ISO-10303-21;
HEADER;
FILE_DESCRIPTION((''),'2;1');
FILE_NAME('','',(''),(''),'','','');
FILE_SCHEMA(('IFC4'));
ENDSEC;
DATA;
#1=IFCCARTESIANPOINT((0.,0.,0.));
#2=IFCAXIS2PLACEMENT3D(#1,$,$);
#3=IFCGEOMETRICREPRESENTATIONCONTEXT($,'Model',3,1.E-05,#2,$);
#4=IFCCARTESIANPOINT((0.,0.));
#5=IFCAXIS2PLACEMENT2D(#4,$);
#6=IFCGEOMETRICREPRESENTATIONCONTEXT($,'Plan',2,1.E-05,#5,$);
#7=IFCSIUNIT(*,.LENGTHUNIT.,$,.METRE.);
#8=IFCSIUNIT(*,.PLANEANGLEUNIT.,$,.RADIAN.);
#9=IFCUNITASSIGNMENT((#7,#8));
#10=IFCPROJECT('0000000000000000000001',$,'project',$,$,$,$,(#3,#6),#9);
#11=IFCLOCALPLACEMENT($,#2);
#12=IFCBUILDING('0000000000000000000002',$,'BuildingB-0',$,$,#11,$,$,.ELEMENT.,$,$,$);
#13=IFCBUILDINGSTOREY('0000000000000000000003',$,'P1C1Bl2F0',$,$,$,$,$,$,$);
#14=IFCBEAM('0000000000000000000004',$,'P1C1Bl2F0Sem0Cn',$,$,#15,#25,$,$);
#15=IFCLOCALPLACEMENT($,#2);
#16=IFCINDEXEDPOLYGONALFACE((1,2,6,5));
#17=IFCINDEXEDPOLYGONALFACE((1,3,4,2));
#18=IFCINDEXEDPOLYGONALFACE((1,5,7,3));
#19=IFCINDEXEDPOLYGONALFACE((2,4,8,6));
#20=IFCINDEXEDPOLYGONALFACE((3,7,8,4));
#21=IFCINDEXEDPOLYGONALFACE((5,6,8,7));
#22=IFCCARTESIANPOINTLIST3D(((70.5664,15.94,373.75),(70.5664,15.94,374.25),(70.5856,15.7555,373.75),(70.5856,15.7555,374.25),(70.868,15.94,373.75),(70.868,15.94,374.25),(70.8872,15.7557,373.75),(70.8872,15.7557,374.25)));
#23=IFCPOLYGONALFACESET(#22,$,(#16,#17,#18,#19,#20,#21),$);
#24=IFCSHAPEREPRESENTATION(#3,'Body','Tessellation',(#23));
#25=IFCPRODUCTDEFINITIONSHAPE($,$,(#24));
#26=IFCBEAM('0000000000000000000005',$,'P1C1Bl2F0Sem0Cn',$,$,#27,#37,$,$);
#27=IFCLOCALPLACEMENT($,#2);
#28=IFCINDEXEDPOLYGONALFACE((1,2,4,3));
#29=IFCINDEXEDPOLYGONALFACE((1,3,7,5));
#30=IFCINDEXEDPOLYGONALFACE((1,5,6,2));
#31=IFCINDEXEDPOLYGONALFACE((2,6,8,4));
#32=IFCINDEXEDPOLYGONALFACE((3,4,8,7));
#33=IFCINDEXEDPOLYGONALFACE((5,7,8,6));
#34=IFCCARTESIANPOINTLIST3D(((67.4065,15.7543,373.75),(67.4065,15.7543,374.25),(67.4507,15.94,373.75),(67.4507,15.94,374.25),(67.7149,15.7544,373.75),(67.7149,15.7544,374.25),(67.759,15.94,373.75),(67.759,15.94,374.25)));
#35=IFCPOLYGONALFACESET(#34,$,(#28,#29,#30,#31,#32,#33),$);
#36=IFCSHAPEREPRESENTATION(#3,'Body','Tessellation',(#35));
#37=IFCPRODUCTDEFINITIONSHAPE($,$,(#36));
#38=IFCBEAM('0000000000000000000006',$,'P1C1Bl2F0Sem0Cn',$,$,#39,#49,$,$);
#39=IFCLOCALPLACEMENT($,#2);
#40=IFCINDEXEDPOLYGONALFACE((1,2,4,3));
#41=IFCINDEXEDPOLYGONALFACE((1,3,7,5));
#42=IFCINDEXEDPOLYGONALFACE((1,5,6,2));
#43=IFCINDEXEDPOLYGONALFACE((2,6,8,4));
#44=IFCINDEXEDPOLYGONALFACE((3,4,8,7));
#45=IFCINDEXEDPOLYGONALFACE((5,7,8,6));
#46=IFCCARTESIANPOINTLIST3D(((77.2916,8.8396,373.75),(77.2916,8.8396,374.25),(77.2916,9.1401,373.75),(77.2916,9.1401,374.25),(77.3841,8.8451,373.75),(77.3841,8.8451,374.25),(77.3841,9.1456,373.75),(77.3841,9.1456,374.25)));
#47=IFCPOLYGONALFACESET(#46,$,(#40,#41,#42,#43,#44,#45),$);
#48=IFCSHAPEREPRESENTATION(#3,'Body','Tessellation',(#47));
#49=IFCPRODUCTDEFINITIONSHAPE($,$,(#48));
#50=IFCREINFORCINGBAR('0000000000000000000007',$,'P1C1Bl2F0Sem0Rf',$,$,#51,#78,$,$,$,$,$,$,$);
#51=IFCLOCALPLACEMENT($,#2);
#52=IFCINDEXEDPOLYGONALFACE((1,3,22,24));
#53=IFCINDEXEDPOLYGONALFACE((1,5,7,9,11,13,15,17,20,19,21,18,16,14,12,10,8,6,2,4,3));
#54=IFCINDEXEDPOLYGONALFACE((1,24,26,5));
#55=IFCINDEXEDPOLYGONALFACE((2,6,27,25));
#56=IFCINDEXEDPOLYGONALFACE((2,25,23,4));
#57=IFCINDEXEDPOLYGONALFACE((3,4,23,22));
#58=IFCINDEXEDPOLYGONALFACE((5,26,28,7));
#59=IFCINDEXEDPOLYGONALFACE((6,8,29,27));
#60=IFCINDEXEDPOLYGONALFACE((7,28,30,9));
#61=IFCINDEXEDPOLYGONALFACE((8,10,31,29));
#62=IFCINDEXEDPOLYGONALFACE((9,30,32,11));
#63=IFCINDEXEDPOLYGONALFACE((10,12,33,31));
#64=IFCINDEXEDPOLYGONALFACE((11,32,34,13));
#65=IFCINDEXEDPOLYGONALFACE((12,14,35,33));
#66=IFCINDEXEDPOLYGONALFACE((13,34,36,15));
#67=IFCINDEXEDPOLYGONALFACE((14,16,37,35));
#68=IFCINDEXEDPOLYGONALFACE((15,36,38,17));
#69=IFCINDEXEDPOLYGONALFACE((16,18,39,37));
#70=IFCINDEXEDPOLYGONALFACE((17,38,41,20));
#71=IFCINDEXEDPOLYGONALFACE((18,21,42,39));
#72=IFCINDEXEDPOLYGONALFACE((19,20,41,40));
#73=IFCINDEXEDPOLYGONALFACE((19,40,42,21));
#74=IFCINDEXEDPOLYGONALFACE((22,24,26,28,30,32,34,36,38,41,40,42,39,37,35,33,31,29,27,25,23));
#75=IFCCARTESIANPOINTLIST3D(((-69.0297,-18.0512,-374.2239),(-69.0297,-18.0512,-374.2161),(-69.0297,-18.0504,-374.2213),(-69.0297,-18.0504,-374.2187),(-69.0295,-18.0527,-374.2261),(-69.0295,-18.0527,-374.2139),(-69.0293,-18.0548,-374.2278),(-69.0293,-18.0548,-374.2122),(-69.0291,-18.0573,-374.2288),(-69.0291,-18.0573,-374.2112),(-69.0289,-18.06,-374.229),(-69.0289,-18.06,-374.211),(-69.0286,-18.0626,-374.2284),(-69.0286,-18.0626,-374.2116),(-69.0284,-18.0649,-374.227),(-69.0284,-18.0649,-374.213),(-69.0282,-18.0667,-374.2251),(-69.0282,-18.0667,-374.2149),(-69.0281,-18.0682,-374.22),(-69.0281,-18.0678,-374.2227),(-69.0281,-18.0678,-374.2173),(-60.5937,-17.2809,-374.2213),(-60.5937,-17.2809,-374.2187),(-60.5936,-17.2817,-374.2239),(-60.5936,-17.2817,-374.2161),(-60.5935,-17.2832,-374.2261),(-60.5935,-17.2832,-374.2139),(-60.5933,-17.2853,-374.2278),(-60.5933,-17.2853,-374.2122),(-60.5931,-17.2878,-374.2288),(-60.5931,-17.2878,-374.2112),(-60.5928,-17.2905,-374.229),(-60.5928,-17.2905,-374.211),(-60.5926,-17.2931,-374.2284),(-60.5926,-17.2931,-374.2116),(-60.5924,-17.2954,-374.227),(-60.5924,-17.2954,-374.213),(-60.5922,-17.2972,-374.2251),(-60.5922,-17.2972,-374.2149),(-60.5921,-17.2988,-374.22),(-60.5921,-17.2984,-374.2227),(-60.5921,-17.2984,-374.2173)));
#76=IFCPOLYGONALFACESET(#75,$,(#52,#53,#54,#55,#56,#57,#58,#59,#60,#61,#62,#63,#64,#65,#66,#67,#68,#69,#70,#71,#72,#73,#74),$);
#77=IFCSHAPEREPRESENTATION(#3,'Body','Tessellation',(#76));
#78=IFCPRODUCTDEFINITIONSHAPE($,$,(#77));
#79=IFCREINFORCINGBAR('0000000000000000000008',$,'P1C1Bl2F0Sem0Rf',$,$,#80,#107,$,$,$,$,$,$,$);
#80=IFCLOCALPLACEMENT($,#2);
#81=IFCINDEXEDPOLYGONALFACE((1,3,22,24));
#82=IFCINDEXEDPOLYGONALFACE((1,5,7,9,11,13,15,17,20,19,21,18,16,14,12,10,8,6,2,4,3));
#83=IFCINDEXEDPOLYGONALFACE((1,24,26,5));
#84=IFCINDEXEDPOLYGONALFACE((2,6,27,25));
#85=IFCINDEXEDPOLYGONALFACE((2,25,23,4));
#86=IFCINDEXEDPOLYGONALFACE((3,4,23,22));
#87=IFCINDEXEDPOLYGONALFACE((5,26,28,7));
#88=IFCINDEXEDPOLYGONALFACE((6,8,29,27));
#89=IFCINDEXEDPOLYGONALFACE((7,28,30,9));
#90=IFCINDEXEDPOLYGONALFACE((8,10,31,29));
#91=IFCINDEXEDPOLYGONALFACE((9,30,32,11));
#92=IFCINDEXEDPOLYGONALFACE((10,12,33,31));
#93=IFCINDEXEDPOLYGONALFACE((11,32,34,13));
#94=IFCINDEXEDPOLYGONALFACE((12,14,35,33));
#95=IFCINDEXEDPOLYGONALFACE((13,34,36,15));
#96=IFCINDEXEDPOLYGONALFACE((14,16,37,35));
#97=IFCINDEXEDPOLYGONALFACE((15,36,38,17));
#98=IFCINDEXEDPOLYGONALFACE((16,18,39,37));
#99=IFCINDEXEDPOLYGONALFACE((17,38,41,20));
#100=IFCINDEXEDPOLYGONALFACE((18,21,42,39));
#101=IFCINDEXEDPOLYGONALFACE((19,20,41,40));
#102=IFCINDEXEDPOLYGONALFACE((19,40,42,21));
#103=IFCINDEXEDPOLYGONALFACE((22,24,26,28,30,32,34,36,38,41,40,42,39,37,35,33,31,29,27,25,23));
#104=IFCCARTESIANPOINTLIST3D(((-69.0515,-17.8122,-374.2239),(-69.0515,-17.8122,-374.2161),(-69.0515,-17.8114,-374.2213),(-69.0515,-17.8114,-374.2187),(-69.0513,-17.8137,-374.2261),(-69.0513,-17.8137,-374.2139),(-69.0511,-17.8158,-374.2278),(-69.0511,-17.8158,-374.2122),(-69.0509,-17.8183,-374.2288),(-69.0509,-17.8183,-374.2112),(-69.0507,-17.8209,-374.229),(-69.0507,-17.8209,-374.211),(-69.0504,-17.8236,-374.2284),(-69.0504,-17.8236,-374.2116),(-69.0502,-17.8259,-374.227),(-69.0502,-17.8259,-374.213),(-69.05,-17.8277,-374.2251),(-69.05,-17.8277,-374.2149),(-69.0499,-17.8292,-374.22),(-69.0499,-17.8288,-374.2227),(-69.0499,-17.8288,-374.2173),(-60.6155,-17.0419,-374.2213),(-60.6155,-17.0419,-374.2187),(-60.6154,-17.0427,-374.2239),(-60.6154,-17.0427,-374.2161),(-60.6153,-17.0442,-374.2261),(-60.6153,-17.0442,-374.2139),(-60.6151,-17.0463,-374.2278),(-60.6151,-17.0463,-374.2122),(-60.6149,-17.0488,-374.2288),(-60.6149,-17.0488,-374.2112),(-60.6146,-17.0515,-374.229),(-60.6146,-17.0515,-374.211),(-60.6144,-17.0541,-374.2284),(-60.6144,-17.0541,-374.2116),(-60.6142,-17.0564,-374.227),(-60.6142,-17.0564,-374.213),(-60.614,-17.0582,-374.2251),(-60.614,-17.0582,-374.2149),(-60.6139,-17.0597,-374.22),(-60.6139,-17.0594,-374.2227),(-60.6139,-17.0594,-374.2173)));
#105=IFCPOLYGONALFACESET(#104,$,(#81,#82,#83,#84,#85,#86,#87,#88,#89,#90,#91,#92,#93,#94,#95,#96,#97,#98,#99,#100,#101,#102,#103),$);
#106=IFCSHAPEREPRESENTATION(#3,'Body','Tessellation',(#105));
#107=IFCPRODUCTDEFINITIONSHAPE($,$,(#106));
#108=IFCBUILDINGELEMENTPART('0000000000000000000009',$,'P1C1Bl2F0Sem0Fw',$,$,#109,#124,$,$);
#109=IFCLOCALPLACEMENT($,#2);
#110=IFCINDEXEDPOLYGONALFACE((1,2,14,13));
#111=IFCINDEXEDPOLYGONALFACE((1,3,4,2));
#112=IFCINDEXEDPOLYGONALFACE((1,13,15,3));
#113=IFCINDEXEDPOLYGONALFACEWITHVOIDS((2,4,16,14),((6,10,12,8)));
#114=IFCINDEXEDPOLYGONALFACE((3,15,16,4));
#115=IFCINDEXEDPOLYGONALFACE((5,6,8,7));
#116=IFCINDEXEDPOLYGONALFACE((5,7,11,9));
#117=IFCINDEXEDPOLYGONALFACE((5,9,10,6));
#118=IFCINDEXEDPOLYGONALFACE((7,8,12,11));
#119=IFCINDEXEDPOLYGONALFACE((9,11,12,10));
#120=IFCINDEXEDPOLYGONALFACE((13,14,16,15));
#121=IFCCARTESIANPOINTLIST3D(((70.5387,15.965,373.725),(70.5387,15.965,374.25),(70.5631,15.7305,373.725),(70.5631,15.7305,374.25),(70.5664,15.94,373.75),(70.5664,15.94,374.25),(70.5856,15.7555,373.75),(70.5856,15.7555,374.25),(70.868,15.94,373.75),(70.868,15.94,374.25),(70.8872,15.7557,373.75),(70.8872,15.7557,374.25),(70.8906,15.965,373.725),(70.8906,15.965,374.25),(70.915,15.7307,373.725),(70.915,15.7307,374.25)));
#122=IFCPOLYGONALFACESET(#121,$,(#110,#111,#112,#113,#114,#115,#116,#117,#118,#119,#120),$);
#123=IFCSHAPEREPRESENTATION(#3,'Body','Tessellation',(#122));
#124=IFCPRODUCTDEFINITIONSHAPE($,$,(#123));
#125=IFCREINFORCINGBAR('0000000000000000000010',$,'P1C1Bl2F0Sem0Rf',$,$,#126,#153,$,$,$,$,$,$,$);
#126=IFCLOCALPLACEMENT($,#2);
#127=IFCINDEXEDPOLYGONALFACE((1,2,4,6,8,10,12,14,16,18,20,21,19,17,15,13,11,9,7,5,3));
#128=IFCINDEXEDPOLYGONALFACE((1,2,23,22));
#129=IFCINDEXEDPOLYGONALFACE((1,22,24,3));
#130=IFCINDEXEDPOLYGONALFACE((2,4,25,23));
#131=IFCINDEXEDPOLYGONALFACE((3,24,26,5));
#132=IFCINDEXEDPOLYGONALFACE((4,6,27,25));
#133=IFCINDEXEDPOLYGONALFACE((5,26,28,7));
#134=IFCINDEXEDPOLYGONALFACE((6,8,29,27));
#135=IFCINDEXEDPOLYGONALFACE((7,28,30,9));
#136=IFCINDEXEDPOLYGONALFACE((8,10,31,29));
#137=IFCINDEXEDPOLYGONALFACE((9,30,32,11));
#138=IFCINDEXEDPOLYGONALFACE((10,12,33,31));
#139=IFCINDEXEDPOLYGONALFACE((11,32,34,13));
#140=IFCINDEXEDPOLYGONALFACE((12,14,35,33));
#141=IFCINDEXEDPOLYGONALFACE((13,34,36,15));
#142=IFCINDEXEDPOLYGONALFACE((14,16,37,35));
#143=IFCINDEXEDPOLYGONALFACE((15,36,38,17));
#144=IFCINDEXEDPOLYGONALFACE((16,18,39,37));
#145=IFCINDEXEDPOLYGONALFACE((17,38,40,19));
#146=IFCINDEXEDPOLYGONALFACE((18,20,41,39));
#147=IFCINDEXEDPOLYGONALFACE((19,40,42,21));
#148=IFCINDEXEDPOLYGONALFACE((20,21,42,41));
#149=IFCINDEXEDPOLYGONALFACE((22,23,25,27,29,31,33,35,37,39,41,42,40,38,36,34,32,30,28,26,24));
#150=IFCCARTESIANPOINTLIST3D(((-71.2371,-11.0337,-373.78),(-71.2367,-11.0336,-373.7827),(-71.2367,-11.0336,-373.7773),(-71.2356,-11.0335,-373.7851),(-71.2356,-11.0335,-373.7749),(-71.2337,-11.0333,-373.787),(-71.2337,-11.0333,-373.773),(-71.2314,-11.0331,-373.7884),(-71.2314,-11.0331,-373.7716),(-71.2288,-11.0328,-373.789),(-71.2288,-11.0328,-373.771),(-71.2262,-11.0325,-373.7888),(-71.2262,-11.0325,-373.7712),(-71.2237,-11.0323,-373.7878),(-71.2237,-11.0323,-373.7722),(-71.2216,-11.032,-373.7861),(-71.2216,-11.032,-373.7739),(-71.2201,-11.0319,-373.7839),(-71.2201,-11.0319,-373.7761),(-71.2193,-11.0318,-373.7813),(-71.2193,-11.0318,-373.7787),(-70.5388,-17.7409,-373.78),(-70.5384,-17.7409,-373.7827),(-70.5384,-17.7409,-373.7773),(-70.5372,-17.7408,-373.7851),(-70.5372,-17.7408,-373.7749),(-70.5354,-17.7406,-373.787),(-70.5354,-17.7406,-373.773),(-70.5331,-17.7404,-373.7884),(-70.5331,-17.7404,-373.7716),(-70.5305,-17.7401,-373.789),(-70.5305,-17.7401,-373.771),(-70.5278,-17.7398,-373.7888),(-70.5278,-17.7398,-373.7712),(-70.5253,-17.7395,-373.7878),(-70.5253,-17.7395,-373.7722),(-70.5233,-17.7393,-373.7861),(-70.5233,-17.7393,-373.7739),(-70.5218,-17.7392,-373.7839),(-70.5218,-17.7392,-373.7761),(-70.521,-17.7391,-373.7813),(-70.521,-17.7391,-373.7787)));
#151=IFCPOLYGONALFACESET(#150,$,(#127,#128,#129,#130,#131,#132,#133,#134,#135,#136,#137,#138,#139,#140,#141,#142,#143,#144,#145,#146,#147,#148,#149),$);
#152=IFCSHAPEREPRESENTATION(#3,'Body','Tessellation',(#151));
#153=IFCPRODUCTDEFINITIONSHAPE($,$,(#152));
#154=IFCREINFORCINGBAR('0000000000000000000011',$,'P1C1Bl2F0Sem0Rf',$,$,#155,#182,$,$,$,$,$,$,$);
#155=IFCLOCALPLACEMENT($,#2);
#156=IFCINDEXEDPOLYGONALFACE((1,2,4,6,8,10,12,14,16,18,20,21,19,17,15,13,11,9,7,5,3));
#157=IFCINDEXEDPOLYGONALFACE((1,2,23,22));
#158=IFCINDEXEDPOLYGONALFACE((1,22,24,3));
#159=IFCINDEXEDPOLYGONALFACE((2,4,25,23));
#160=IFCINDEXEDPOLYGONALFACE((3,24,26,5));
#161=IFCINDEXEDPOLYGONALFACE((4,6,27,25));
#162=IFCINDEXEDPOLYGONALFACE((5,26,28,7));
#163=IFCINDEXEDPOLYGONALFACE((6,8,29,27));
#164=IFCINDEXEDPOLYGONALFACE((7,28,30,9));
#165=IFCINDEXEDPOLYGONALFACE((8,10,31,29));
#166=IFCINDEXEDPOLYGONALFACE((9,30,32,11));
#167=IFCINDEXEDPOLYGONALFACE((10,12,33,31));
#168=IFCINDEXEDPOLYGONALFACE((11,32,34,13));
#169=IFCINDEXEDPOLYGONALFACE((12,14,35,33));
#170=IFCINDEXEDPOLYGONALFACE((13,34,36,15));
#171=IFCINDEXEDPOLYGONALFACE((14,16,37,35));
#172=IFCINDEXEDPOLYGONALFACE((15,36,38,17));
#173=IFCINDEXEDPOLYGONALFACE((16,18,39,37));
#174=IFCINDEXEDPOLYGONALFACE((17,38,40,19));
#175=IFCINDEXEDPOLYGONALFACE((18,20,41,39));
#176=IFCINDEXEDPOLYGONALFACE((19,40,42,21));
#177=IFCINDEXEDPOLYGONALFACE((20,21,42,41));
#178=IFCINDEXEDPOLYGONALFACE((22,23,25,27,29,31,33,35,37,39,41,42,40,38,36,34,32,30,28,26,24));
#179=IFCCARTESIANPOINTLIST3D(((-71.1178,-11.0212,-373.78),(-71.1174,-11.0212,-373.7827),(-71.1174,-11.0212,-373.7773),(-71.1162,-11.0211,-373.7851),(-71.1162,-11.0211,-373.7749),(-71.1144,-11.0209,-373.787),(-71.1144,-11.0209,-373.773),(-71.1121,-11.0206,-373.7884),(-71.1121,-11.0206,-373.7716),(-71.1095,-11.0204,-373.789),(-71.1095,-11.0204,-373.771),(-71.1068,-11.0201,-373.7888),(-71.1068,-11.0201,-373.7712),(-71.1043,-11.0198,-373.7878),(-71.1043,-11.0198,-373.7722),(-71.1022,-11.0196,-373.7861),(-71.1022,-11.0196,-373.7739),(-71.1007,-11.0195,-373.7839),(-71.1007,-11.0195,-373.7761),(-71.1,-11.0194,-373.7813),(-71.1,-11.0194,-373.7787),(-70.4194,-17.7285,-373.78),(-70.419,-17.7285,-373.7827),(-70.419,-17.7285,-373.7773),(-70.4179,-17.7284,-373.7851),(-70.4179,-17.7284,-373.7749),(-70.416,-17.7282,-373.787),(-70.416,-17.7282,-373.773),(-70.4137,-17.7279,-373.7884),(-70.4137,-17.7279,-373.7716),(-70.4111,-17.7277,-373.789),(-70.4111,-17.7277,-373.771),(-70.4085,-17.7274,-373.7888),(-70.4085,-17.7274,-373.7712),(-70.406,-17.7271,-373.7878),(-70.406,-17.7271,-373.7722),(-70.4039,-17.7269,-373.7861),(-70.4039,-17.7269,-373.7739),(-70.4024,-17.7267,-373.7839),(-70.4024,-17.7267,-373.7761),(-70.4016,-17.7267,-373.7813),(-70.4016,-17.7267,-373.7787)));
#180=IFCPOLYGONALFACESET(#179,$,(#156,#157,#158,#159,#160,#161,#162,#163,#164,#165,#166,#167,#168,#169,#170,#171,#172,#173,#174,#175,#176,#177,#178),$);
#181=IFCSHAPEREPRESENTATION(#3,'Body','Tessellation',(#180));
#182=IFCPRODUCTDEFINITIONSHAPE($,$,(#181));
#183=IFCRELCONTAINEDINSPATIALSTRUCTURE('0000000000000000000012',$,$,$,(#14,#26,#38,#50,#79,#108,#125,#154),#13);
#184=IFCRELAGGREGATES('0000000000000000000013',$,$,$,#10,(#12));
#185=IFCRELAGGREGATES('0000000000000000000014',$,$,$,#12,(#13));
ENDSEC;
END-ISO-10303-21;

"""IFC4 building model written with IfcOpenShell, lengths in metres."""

from ifc_helpers import new_model, entity, si_unit, origin, origin_2d, place, context, project, spatial, polyline, outline, extrude, element, save


model = new_model("IFC4")

# Units and contexts
model_context = context("Model", 3, precision=1e-05, world=origin())
plan_context = context("Plan", 2, precision=1e-05, world=origin_2d())
ifc_project = project(units=[si_unit("LENGTHUNIT", "METRE"), si_unit("PLANEANGLEUNIT", "RADIAN")], contexts=[model_context, plan_context])

# Building, storey
building_placement = place(None, origin())
building = spatial("IfcBuilding", under=ifc_project, at=building_placement, Name="BuildingB-0", CompositionType="ELEMENT")
storey = spatial("IfcBuildingStorey", under=building, Name="P1C1Bl2F0")

# Beams
element("IfcBeam", 1, inside=storey, Name="P1C1Bl2F0Sem0Cn", context=model_context, shape_type="SweptSolid", body=[
    extrude(outline(polyline([(70.8872, 15.7557, 373.75), (70.868, 15.94, 373.75), (70.5664, 15.94, 373.75), (70.5856, 15.7555, 373.75), (70.8872, 15.7557, 373.75)])), None, (0.0, 0.0, 1.0), 0.5),
])
element("IfcBeam", 2, inside=storey, Name="P1C1Bl2F0Sem0Cn", context=model_context, shape_type="SweptSolid", body=[
    extrude(outline(polyline([(67.7149, 15.7544, 373.75), (67.759, 15.94, 373.75), (67.4507, 15.94, 373.75), (67.4065, 15.7543, 373.75), (67.7149, 15.7544, 373.75)])), None, (0.0, 0.0, 1.0), 0.5),
])
element("IfcBeam", 3, inside=storey, Name="P1C1Bl2F0Sem0Cn", context=model_context, shape_type="SweptSolid", body=[
    extrude(outline(polyline([(77.3841, 8.8451, 373.75), (77.2916, 8.8396, 373.75), (77.2916, 9.1401, 373.75), (77.3841, 9.1456, 373.75), (77.3841, 8.8451, 373.75)])), None, (0.0, 0.0, 1.0), 0.5),
])

# Reinforcing bars
element("IfcReinforcingBar", 4, inside=storey, Name="P1C1Bl2F0Sem0Rf", context=model_context, shape_type="SweptSolid", body=[
    entity("IfcSurfaceCurveSweptAreaSolid", entity("IfcCircleProfileDef", "AREA", None, None, 0.009), None, entity("IfcPolyline", [entity("IfcCartesianPoint", [69.0289, 18.0593, 374.22]), entity("IfcCartesianPoint", [60.5929, 17.2898, 374.22])]), None, None, entity("IfcPlane", entity("IfcAxis2Placement3D", entity("IfcCartesianPoint", [69.0289, 18.0593, 374.22]), entity("IfcDirection", [0.0, 0.0, 1.0]), entity("IfcDirection", [1.0, 0.0, 0.0])))),
])
element("IfcReinforcingBar", 5, inside=storey, Name="P1C1Bl2F0Sem0Rf", context=model_context, shape_type="SweptSolid", body=[
    entity("IfcSurfaceCurveSweptAreaSolid", entity("IfcCircleProfileDef", "AREA", None, None, 0.009), None, entity("IfcPolyline", [entity("IfcCartesianPoint", [69.0507, 17.8203, 374.22]), entity("IfcCartesianPoint", [60.6147, 17.0508, 374.22])]), None, None, entity("IfcPlane", entity("IfcAxis2Placement3D", entity("IfcCartesianPoint", [69.0507, 17.8203, 374.22]), entity("IfcDirection", [0.0, 0.0, 1.0]), entity("IfcDirection", [1.0, 0.0, 0.0])))),
])

# Building element part, opening
building_element_part_1 = element("IfcBuildingElementPart", 6, inside=storey, Name="P1C1Bl2F0Sem0Fw", context=model_context, shape_type="SweptSolid", body=[
    extrude(outline(polyline([(70.915, 15.7307, 373.725), (70.8906, 15.965, 373.725), (70.5387, 15.965, 373.725), (70.5631, 15.7305, 373.725), (70.915, 15.7307, 373.725)])), None, (0.0, 0.0, 1.0), 0.525),
])
element("IfcOpeningElement", 7, inside=storey, cuts=building_element_part_1, context=model_context, shape_type="SweptSolid", body=[
    extrude(outline(polyline([(70.8872, 15.7557, 373.75), (70.868, 15.94, 373.75), (70.5664, 15.94, 373.75), (70.5856, 15.7555, 373.75), (70.8872, 15.7557, 373.75)])), None, (0.0, 0.0, 1.0), 0.5),
])

# Reinforcing bars
element("IfcReinforcingBar", 8, inside=storey, Name="P1C1Bl2F0Sem0Rf", context=model_context, shape_type="SweptSolid", body=[
    entity("IfcSurfaceCurveSweptAreaSolid", entity("IfcCircleProfileDef", "AREA", None, None, 0.009), None, entity("IfcPolyline", [entity("IfcCartesianPoint", [70.5298, 17.74, 373.78]), entity("IfcCartesianPoint", [71.2282, 11.0327, 373.78])]), None, None, entity("IfcPlane", entity("IfcAxis2Placement3D", entity("IfcCartesianPoint", [70.5298, 17.74, 373.78]), entity("IfcDirection", [0.0, 0.0, 1.0]), entity("IfcDirection", [1.0, 0.0, 0.0])))),
])
element("IfcReinforcingBar", 9, inside=storey, Name="P1C1Bl2F0Sem0Rf", context=model_context, shape_type="SweptSolid", body=[
    entity("IfcSurfaceCurveSweptAreaSolid", entity("IfcCircleProfileDef", "AREA", None, None, 0.009), None, entity("IfcPolyline", [entity("IfcCartesianPoint", [70.4105, 17.7276, 373.78]), entity("IfcCartesianPoint", [71.1088, 11.0203, 373.78])]), None, None, entity("IfcPlane", entity("IfcAxis2Placement3D", entity("IfcCartesianPoint", [70.4105, 17.7276, 373.78]), entity("IfcDirection", [0.0, 0.0, 1.0]), entity("IfcDirection", [1.0, 0.0, 0.0])))),
])

save(model, "model.ifc")
